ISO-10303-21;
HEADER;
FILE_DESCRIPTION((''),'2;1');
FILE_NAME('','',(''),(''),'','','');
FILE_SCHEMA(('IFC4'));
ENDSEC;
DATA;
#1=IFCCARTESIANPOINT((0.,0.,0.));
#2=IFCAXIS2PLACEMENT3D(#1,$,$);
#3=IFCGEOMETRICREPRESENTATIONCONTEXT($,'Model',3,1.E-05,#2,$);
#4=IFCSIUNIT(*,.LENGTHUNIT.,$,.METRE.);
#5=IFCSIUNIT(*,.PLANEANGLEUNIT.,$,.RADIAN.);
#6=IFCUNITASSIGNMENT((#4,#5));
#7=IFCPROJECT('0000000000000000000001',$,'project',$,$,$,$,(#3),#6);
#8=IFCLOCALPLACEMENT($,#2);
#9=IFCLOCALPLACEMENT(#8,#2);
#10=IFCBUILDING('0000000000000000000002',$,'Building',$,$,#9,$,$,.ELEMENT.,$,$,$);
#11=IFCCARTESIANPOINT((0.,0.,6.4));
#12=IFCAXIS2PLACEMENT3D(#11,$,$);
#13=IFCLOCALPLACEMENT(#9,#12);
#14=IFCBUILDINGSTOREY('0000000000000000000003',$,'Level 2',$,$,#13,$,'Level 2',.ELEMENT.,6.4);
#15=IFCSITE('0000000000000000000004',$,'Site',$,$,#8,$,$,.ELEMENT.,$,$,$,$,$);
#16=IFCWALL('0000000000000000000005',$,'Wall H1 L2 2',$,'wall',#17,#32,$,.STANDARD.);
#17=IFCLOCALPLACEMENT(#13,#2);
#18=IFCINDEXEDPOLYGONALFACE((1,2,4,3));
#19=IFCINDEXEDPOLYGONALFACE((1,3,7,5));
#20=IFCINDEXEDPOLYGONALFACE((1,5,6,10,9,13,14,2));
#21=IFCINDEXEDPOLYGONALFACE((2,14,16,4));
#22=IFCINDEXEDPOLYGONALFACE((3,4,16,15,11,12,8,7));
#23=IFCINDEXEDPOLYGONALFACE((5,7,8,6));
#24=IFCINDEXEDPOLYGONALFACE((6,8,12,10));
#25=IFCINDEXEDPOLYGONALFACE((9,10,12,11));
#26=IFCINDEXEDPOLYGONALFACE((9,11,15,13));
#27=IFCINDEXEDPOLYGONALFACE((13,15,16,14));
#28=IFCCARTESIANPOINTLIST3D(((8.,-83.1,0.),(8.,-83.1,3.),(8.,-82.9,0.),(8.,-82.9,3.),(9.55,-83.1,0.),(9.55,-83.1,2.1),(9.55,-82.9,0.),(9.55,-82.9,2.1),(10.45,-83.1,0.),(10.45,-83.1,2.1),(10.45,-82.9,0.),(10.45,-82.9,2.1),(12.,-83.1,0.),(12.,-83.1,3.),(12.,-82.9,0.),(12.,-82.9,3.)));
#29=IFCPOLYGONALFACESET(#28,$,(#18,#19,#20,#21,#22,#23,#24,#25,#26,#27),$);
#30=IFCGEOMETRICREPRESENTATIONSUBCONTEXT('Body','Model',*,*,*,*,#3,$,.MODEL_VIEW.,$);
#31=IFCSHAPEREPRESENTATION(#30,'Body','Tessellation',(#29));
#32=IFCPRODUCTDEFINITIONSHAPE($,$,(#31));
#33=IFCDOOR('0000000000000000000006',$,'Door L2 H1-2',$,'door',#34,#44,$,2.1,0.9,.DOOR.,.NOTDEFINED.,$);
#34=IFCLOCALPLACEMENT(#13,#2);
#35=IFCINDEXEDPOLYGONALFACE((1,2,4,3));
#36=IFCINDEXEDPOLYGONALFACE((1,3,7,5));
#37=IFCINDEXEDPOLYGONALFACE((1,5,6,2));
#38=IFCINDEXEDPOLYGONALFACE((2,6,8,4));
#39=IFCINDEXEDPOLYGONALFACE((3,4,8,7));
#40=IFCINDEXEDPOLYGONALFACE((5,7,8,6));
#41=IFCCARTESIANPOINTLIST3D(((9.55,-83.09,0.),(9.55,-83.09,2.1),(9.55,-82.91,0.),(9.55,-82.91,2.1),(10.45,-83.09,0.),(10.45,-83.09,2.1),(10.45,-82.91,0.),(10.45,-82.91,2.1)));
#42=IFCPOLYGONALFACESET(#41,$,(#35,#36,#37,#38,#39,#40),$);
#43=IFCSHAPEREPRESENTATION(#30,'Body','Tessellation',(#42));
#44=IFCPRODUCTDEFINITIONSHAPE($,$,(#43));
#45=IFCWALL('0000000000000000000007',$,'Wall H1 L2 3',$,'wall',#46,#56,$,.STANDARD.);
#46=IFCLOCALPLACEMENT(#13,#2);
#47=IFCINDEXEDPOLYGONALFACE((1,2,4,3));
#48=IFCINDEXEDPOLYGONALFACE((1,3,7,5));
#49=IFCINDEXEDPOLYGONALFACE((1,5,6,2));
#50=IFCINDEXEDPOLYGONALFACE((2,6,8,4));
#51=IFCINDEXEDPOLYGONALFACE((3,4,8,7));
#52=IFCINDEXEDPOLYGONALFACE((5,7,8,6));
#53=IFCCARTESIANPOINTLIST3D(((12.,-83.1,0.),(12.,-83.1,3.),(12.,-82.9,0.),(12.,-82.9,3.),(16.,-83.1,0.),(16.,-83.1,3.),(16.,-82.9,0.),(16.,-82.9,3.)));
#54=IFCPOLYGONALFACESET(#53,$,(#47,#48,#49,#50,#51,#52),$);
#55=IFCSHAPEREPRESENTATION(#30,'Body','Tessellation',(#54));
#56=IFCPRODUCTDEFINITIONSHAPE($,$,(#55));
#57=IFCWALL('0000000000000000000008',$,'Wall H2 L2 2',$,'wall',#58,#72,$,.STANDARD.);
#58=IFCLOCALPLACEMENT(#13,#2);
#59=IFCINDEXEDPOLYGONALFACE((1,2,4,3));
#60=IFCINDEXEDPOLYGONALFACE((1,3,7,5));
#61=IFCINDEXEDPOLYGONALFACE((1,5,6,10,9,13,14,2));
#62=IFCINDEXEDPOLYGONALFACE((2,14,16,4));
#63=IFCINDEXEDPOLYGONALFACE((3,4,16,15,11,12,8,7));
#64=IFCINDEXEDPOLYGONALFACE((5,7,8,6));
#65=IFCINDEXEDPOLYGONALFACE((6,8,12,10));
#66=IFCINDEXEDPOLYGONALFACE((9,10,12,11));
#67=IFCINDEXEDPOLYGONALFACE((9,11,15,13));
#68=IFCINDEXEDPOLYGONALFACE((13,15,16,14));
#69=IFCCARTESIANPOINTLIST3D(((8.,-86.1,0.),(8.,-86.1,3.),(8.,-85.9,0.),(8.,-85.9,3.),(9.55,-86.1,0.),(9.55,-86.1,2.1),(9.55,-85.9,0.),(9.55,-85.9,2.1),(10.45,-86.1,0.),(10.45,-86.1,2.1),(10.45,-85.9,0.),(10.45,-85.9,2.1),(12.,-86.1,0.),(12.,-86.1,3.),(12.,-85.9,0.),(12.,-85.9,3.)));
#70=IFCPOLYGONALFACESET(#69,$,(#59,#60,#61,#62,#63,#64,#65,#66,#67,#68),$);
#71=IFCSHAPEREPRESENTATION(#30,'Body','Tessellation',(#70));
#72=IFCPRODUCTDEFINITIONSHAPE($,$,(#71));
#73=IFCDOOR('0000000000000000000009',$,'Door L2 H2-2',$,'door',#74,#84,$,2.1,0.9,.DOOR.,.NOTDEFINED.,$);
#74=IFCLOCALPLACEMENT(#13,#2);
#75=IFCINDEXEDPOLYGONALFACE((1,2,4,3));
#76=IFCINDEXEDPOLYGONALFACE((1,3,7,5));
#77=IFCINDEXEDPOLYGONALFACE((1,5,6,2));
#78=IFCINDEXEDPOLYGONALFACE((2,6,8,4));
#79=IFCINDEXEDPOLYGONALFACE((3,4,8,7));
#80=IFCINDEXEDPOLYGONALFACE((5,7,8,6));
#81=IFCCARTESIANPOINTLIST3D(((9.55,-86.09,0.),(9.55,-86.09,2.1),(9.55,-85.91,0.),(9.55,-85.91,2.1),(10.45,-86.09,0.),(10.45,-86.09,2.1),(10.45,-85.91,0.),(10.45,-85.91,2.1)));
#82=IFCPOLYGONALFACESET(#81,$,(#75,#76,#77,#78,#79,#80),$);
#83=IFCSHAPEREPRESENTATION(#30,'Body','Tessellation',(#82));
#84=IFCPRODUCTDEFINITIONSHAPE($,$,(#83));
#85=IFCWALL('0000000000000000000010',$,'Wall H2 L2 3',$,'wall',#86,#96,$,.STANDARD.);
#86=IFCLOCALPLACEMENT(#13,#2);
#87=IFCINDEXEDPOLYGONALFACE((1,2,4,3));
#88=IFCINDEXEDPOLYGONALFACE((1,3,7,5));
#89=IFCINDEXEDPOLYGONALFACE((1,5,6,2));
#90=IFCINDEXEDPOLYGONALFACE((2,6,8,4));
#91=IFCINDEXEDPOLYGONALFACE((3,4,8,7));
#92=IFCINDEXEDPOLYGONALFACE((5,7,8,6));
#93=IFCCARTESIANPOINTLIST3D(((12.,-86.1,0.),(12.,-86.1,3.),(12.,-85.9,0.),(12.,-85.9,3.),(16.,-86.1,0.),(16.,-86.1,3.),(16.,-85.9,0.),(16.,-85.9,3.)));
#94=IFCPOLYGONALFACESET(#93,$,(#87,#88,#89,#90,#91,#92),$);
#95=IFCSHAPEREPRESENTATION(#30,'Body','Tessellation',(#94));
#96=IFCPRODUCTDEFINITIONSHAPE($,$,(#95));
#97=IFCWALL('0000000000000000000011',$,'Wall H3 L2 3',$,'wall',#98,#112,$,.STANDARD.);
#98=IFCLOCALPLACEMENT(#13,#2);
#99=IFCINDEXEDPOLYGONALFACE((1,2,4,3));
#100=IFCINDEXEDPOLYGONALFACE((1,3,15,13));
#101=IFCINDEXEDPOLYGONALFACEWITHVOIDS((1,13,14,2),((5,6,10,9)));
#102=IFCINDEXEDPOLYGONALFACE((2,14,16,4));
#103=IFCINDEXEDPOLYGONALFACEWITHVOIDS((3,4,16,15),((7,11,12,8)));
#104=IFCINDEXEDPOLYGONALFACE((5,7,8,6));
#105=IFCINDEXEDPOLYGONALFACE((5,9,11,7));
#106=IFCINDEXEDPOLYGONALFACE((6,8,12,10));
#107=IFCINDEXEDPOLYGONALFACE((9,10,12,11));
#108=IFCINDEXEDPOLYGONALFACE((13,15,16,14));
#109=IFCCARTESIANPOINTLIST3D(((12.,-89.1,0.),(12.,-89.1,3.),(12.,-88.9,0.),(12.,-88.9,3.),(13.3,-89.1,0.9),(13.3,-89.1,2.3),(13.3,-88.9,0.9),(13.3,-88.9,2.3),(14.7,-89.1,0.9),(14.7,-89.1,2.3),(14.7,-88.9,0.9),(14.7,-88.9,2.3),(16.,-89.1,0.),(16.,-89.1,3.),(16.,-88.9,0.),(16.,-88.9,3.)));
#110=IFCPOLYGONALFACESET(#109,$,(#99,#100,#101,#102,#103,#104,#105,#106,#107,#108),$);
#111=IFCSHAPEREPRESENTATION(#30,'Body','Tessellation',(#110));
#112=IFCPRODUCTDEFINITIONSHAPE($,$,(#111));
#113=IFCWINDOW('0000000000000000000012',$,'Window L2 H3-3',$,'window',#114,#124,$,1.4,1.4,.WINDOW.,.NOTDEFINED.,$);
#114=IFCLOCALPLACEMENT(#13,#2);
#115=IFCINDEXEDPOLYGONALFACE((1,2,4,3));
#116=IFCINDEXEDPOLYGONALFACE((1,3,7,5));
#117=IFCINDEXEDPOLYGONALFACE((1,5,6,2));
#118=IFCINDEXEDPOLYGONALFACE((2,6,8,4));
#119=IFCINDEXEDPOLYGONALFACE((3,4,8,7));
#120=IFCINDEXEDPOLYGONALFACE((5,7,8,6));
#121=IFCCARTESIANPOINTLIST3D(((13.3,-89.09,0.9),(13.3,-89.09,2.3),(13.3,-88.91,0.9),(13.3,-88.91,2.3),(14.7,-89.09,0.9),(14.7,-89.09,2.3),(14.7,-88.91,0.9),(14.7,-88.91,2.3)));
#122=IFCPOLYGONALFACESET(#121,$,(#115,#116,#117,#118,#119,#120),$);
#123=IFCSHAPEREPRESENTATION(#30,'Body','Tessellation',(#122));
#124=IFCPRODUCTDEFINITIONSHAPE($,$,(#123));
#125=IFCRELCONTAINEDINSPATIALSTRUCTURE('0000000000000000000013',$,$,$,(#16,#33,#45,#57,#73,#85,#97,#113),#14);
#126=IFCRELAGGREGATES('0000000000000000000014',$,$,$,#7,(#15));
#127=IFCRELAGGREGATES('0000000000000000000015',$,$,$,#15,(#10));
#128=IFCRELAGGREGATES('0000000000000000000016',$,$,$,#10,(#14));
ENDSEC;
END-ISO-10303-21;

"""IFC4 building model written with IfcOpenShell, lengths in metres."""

from ifc_helpers import new_model, si_unit, frame, frame_2d, origin, origin_2d, place, context, subcontext, project, spatial, rectangle, extrude, element, fill, save


model = new_model("IFC4")

# Units and contexts
model_context = context("Model", 3, precision=1e-05, world=origin())
body_context = subcontext(model_context, "Body", "Model", "MODEL_VIEW")
ifc_project = project(units=[si_unit("LENGTHUNIT", "METRE"), si_unit("PLANEANGLEUNIT", "RADIAN")], contexts=[model_context])

# Site, building, storey
site_placement = place(None, origin())
site = spatial("IfcSite", under=ifc_project, at=site_placement, Name="Site", CompositionType="ELEMENT")
building_placement = place(site_placement, origin())
building = spatial("IfcBuilding", under=site, at=building_placement, Name="Building", CompositionType="ELEMENT")
storey_placement = place(building_placement, frame((0.0, 0.0, 6.4)))
storey = spatial("IfcBuildingStorey", under=building, at=storey_placement, Name="Level 2", LongName="Level 2", CompositionType="ELEMENT", Elevation=6.4)

# Wall, opening, door
wall_1_placement = place(storey_placement, frame((8.0, -83.0, 0.0), z_axis=(0.0, 0.0, 1.0), x_axis=(1.0, 0.0, 0.0)))
wall_1 = element("IfcWall", 1, at=wall_1_placement, inside=storey, Name="Wall H1 L2 2", ObjectType="wall", PredefinedType="STANDARD", context=body_context, shape_type="SweptSolid", body=[
    extrude(rectangle(XDim=4.0, YDim=0.2, at=frame_2d((2.0, 0.0))), origin(), (0.0, 0.0, 1.0), 3.0),
])
opening_1_placement = place(storey_placement, frame((10.0, -83.0, 0.0), z_axis=(0.0, 0.0, 1.0), x_axis=(1.0, 0.0, 0.0)))
opening_1 = element("IfcOpeningElement", 2, at=opening_1_placement, cuts=wall_1, ObjectType="Opening", PredefinedType="OPENING", context=body_context, shape_type="SweptSolid", body=[
    extrude(rectangle(XDim=0.9, YDim=0.22, at=origin_2d()), origin(), (0.0, 0.0, 1.0), 2.1),
])
door_1_placement = place(storey_placement, frame((10.0, -83.0, 0.0), z_axis=(0.0, 0.0, 1.0), x_axis=(1.0, 0.0, 0.0)))
door_1 = element("IfcDoor", 3, at=door_1_placement, inside=storey, Name="Door L2 H1-2", ObjectType="door", OperationType="NOTDEFINED", OverallHeight=2.1, OverallWidth=0.9, PredefinedType="DOOR", context=body_context, shape_type="SweptSolid", body=[
    extrude(rectangle(XDim=0.9, YDim=0.18, at=origin_2d()), origin(), (0.0, 0.0, 1.0), 2.1),
])
fill(opening_1, door_1)

# Wall
wall_2_placement = place(storey_placement, frame((12.0, -83.0, 0.0), z_axis=(0.0, 0.0, 1.0), x_axis=(1.0, 0.0, 0.0)))
element("IfcWall", 4, at=wall_2_placement, inside=storey, Name="Wall H1 L2 3", ObjectType="wall", PredefinedType="STANDARD", context=body_context, shape_type="SweptSolid", body=[
    extrude(rectangle(XDim=4.0, YDim=0.2, at=frame_2d((2.0, 0.0))), origin(), (0.0, 0.0, 1.0), 3.0),
])

# Wall, opening, door
wall_3_placement = place(storey_placement, frame((8.0, -86.0, 0.0), z_axis=(0.0, 0.0, 1.0), x_axis=(1.0, 0.0, 0.0)))
wall_3 = element("IfcWall", 5, at=wall_3_placement, inside=storey, Name="Wall H2 L2 2", ObjectType="wall", PredefinedType="STANDARD", context=body_context, shape_type="SweptSolid", body=[
    extrude(rectangle(XDim=4.0, YDim=0.2, at=frame_2d((2.0, 0.0))), origin(), (0.0, 0.0, 1.0), 3.0),
])
opening_2_placement = place(storey_placement, frame((10.0, -86.0, 0.0), z_axis=(0.0, 0.0, 1.0), x_axis=(1.0, 0.0, 0.0)))
opening_2 = element("IfcOpeningElement", 6, at=opening_2_placement, cuts=wall_3, ObjectType="Opening", PredefinedType="OPENING", context=body_context, shape_type="SweptSolid", body=[
    extrude(rectangle(XDim=0.9, YDim=0.22, at=origin_2d()), origin(), (0.0, 0.0, 1.0), 2.1),
])
door_2_placement = place(storey_placement, frame((10.0, -86.0, 0.0), z_axis=(0.0, 0.0, 1.0), x_axis=(1.0, 0.0, 0.0)))
door_2 = element("IfcDoor", 7, at=door_2_placement, inside=storey, Name="Door L2 H2-2", ObjectType="door", OperationType="NOTDEFINED", OverallHeight=2.1, OverallWidth=0.9, PredefinedType="DOOR", context=body_context, shape_type="SweptSolid", body=[
    extrude(rectangle(XDim=0.9, YDim=0.18, at=origin_2d()), origin(), (0.0, 0.0, 1.0), 2.1),
])
fill(opening_2, door_2)

# Wall
wall_4_placement = place(storey_placement, frame((12.0, -86.0, 0.0), z_axis=(0.0, 0.0, 1.0), x_axis=(1.0, 0.0, 0.0)))
element("IfcWall", 8, at=wall_4_placement, inside=storey, Name="Wall H2 L2 3", ObjectType="wall", PredefinedType="STANDARD", context=body_context, shape_type="SweptSolid", body=[
    extrude(rectangle(XDim=4.0, YDim=0.2, at=frame_2d((2.0, 0.0))), origin(), (0.0, 0.0, 1.0), 3.0),
])

# Wall, opening, window
wall_5_placement = place(storey_placement, frame((12.0, -89.0, 0.0), z_axis=(0.0, 0.0, 1.0), x_axis=(1.0, 0.0, 0.0)))
wall_5 = element("IfcWall", 9, at=wall_5_placement, inside=storey, Name="Wall H3 L2 3", ObjectType="wall", PredefinedType="STANDARD", context=body_context, shape_type="SweptSolid", body=[
    extrude(rectangle(XDim=4.0, YDim=0.2, at=frame_2d((2.0, 0.0))), origin(), (0.0, 0.0, 1.0), 3.0),
])
opening_3_placement = place(storey_placement, frame((14.0, -89.0, 0.9), z_axis=(0.0, 0.0, 1.0), x_axis=(1.0, 0.0, 0.0)))
opening_3 = element("IfcOpeningElement", 10, at=opening_3_placement, cuts=wall_5, ObjectType="Opening", PredefinedType="OPENING", context=body_context, shape_type="SweptSolid", body=[
    extrude(rectangle(XDim=1.4, YDim=0.22, at=origin_2d()), origin(), (0.0, 0.0, 1.0), 1.4),
])
window_1_placement = place(storey_placement, frame((14.0, -89.0, 0.9), z_axis=(0.0, 0.0, 1.0), x_axis=(1.0, 0.0, 0.0)))
window_1 = element("IfcWindow", 11, at=window_1_placement, inside=storey, Name="Window L2 H3-3", ObjectType="window", OverallHeight=1.4, OverallWidth=1.4, PartitioningType="NOTDEFINED", PredefinedType="WINDOW", context=body_context, shape_type="SweptSolid", body=[
    extrude(rectangle(XDim=1.4, YDim=0.18, at=origin_2d()), origin(), (0.0, 0.0, 1.0), 1.4),
])
fill(opening_3, window_1)

save(model, "model.ifc")
